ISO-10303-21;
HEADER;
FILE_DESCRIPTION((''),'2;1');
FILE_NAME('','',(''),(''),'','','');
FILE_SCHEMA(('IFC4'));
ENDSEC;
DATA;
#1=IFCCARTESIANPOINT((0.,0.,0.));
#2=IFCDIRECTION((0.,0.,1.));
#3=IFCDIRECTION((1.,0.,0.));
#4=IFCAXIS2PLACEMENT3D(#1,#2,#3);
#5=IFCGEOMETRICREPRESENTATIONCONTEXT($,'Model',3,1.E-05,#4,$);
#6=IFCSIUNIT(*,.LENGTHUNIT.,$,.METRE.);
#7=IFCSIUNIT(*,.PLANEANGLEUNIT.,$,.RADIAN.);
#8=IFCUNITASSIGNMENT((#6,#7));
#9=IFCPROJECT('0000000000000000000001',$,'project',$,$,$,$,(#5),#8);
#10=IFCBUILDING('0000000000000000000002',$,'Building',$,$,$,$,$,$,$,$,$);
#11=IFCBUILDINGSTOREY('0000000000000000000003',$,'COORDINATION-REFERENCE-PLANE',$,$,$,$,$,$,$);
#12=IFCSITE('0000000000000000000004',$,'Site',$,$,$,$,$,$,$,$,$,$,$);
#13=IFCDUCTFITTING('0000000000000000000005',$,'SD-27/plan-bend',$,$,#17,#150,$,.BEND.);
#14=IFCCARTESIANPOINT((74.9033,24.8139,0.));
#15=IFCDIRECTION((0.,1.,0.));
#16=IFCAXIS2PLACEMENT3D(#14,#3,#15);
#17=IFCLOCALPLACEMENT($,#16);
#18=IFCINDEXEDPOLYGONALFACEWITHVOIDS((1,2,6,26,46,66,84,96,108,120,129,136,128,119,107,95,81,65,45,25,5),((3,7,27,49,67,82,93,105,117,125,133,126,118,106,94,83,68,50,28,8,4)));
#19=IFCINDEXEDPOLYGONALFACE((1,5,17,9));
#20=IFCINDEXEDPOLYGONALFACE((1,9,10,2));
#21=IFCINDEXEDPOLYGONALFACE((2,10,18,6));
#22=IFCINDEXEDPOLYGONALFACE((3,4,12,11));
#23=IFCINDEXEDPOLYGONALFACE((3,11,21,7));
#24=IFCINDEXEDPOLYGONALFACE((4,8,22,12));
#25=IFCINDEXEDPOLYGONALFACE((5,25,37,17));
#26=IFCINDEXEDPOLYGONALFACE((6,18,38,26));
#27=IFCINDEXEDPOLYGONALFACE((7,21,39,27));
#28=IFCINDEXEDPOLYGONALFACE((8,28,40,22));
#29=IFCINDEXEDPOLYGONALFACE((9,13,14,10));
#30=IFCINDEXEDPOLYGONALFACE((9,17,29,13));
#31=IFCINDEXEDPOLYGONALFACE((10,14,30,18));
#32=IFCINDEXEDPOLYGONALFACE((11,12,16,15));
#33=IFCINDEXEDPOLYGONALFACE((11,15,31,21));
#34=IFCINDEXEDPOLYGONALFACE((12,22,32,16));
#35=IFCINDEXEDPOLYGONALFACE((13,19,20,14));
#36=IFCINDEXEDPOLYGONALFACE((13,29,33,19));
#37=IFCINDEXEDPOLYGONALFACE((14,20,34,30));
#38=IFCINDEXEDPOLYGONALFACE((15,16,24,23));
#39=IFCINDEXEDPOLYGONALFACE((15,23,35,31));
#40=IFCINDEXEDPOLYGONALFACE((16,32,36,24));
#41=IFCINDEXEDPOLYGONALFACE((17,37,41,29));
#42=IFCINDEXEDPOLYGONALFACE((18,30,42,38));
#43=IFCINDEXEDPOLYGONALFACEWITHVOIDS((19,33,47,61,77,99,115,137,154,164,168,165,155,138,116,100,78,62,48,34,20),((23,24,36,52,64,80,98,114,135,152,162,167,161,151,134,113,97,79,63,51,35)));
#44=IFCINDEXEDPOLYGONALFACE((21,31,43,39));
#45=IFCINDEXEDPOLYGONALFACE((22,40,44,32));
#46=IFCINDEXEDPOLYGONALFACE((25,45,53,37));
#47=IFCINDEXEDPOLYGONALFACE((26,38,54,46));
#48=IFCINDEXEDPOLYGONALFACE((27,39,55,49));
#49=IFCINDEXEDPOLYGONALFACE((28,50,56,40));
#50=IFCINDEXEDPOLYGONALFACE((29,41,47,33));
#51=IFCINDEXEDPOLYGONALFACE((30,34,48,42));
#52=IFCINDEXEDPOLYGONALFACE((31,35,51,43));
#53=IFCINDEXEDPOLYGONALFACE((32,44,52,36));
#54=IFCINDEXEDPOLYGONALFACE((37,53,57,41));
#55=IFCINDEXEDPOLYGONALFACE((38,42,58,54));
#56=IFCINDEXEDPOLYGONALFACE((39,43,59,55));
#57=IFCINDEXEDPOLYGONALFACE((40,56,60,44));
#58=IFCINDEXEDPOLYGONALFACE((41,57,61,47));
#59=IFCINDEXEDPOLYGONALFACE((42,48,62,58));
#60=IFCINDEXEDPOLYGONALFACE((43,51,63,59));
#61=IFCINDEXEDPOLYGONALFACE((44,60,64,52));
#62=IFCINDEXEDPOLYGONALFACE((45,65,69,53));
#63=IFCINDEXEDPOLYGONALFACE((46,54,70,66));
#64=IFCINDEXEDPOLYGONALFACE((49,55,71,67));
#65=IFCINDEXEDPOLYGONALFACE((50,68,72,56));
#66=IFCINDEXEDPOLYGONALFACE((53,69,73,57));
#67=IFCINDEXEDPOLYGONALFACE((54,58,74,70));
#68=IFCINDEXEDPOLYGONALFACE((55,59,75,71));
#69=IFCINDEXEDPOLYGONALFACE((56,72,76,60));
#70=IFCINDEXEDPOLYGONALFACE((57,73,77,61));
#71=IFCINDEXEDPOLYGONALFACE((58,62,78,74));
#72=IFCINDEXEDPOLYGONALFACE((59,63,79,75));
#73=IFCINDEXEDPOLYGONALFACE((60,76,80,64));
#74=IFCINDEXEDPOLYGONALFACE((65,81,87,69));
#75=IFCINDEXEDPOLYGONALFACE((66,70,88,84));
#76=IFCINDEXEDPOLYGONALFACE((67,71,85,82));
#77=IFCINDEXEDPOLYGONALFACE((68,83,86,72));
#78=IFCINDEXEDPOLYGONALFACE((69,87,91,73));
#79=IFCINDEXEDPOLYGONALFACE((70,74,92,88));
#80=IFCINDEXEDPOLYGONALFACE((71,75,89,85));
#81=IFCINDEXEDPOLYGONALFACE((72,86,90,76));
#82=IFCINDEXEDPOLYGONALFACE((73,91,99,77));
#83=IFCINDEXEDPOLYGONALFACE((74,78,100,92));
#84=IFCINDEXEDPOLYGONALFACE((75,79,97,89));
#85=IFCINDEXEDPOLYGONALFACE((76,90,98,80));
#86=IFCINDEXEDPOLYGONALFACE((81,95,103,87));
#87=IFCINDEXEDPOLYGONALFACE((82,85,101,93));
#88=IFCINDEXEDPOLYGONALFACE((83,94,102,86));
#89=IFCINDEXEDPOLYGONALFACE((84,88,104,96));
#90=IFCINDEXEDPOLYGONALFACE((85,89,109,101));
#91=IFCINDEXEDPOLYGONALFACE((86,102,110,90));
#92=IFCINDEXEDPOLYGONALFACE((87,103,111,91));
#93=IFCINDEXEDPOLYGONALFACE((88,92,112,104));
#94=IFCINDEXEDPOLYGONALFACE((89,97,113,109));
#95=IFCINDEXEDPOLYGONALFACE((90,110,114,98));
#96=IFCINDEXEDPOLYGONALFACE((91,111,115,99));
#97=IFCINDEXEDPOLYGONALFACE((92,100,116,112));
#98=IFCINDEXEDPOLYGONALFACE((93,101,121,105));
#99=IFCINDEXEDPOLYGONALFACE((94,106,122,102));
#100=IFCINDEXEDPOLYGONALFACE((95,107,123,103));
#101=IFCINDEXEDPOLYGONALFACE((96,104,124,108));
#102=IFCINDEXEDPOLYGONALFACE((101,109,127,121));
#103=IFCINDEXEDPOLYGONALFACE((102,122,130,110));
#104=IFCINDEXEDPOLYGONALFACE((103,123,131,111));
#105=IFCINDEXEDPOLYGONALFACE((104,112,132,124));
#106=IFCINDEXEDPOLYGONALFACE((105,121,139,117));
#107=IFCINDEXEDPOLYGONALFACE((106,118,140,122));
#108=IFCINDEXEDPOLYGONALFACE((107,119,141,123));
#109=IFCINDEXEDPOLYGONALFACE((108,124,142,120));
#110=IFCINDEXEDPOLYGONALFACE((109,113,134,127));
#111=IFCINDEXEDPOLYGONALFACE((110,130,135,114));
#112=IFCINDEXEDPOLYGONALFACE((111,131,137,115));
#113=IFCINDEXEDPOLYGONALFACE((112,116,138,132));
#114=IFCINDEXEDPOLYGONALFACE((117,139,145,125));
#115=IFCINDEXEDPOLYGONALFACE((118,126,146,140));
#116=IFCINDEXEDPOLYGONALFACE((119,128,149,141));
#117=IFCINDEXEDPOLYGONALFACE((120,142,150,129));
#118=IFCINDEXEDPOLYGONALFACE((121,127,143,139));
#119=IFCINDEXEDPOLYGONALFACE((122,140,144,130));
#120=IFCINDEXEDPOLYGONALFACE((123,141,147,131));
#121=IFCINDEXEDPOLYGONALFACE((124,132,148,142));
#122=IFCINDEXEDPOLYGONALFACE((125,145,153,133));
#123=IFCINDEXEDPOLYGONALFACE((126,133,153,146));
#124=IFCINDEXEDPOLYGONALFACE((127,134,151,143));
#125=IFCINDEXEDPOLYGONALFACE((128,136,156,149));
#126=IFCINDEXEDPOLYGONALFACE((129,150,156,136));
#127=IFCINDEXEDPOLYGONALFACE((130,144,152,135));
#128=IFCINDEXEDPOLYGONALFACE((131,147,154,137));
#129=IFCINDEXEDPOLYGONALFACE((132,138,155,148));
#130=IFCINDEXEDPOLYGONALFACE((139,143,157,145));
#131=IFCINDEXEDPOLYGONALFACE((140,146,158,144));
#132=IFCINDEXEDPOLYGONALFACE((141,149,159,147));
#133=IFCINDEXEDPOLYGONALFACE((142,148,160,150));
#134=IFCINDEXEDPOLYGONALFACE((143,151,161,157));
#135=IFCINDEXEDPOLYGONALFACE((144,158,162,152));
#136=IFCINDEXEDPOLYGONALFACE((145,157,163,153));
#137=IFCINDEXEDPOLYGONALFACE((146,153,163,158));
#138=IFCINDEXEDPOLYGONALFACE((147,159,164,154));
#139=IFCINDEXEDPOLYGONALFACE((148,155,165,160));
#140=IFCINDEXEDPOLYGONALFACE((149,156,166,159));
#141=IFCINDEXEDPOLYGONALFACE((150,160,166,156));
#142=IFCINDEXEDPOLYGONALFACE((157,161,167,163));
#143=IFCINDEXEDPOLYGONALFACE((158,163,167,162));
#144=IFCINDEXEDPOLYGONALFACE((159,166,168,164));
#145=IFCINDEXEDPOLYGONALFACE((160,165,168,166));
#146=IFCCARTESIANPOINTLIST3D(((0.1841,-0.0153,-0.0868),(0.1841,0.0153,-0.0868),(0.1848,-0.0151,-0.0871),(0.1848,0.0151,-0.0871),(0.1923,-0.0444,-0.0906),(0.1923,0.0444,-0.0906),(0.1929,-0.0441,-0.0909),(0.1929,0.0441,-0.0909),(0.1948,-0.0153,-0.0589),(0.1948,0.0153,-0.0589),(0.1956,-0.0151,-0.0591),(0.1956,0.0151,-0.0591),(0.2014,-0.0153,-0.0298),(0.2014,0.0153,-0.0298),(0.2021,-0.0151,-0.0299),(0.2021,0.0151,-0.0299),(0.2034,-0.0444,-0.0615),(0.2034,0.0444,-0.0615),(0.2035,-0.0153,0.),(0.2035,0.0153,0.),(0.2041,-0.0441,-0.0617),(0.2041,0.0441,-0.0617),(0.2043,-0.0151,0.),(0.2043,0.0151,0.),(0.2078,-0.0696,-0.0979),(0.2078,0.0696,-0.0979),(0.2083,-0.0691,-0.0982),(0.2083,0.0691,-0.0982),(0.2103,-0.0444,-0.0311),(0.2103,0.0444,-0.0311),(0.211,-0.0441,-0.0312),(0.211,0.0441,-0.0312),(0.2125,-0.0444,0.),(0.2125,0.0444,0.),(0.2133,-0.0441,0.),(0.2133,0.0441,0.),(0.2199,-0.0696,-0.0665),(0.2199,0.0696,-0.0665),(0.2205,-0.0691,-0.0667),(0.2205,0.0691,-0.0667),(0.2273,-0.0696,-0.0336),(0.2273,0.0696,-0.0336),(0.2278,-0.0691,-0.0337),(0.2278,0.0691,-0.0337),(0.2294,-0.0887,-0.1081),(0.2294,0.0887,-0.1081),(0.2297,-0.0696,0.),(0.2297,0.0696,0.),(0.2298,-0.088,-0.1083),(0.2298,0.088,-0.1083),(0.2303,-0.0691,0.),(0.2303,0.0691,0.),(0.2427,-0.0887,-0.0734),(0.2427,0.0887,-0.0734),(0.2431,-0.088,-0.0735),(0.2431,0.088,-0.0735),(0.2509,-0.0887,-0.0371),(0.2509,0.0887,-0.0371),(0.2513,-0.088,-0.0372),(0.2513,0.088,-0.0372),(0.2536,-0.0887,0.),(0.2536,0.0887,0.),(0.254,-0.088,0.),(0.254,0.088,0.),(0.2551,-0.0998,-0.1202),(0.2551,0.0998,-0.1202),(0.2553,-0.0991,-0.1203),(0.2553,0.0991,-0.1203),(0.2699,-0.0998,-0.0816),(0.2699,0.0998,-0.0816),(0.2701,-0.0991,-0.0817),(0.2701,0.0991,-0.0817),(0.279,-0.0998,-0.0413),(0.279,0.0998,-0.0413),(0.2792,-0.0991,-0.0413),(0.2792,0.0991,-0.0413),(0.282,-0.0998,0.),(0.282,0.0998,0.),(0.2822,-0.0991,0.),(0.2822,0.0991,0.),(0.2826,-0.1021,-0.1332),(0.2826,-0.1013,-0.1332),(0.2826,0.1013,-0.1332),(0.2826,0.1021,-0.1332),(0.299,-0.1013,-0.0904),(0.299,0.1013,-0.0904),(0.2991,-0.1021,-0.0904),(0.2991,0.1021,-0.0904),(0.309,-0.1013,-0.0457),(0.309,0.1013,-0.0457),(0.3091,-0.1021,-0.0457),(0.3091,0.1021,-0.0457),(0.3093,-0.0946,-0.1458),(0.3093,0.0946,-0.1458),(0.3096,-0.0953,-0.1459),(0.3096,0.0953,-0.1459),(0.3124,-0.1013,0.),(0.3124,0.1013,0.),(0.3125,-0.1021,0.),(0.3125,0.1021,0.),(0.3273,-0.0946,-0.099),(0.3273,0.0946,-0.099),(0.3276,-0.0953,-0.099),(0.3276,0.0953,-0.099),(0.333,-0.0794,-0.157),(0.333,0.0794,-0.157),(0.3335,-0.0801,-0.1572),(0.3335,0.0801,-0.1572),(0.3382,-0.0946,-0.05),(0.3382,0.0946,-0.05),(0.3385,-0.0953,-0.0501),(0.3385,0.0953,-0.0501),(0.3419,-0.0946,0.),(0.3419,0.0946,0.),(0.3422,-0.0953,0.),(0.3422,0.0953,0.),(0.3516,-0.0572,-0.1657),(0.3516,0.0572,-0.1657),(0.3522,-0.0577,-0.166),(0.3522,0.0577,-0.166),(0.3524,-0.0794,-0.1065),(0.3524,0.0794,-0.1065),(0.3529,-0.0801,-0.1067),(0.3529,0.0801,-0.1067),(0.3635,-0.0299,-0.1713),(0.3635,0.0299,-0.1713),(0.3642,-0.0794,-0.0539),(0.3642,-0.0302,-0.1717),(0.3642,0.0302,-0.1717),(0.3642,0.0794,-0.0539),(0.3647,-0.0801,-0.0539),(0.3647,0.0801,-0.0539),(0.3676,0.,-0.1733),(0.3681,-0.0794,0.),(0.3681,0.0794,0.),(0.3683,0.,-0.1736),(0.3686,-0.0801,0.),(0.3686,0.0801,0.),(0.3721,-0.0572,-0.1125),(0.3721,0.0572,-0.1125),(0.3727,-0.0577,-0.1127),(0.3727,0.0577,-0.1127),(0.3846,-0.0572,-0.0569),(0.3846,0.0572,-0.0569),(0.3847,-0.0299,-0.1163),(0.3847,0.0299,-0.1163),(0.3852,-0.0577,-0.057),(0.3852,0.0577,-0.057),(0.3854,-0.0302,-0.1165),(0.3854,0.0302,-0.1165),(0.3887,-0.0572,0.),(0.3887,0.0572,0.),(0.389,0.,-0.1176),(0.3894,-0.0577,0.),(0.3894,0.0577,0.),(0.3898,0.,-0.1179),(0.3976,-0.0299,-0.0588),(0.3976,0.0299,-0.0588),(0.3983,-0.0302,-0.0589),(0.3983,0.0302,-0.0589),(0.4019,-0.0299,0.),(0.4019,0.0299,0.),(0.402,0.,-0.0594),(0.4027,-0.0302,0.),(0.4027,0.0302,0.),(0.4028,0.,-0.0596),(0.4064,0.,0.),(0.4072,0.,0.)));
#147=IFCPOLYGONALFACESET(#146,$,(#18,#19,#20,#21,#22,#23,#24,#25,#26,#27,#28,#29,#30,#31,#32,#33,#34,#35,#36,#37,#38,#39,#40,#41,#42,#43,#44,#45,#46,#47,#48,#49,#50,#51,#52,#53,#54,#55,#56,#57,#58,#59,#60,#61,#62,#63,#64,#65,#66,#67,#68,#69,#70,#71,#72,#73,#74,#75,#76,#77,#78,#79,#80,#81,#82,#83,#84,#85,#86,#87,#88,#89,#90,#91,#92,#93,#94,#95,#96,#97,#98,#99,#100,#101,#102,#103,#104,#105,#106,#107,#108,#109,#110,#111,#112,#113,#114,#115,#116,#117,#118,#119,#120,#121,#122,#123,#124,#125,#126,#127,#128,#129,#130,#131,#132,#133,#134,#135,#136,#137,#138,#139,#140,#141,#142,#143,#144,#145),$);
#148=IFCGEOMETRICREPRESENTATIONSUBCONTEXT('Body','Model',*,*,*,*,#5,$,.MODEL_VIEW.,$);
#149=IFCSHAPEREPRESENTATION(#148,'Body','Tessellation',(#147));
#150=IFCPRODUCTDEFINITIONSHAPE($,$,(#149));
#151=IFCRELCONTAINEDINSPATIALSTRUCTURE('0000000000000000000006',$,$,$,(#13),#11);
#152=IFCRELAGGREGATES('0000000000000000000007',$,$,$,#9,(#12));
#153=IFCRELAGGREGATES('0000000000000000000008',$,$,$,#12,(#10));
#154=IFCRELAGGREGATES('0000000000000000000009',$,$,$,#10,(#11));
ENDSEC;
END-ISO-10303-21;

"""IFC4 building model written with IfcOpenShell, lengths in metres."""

from ifc_helpers import new_model, entity, si_unit, frame, origin_with_axes, place, context, subcontext, project, spatial, element, save


model = new_model("IFC4")

# Units and contexts
model_context = context("Model", 3, precision=1e-05, world=origin_with_axes())
body_context_1 = subcontext(model_context, "Body", "Model", "MODEL_VIEW")
ifc_project = project(units=[si_unit("LENGTHUNIT", "METRE"), si_unit("PLANEANGLEUNIT", "RADIAN")], contexts=[model_context])

# Site, building, storey
site = spatial("IfcSite", under=ifc_project, Name="Site")
building = spatial("IfcBuilding", under=site, Name="Building")
storey = spatial("IfcBuildingStorey", under=building, Name="COORDINATION-REFERENCE-PLANE")

# Duct fitting
duct_fitting_1_placement = place(None, frame((74.9033, 24.8139, 0.0), z_axis=(1.0, 0.0, 0.0), x_axis=(0.0, 1.0, 0.0)))
element("IfcDuctFitting", 1, at=duct_fitting_1_placement, inside=storey, Name="SD-27/plan-bend", PredefinedType="BEND", context=body_context_1, shape_type="SweptSolid", body=[
    entity("IfcRevolvedAreaSolid", entity("IfcCircleHollowProfileDef", "AREA", None, entity("IfcAxis2Placement2D", entity("IfcCartesianPoint", [0.3048, 0.0])), 0.1024, 0.0008), entity("IfcAxis2Placement3D", entity("IfcCartesianPoint", [0.0, 0.0, 0.0]), entity("IfcDirection", [0.0, 0.0, 1.0]), entity("IfcDirection", [1.0, 0.0, 0.0])), entity("IfcAxis1Placement", entity("IfcCartesianPoint", [0.0, 0.0, 0.0]), entity("IfcDirection", [0.0, 1.0, 0.0])), 0.440428),
])

save(model, "model.ifc")
